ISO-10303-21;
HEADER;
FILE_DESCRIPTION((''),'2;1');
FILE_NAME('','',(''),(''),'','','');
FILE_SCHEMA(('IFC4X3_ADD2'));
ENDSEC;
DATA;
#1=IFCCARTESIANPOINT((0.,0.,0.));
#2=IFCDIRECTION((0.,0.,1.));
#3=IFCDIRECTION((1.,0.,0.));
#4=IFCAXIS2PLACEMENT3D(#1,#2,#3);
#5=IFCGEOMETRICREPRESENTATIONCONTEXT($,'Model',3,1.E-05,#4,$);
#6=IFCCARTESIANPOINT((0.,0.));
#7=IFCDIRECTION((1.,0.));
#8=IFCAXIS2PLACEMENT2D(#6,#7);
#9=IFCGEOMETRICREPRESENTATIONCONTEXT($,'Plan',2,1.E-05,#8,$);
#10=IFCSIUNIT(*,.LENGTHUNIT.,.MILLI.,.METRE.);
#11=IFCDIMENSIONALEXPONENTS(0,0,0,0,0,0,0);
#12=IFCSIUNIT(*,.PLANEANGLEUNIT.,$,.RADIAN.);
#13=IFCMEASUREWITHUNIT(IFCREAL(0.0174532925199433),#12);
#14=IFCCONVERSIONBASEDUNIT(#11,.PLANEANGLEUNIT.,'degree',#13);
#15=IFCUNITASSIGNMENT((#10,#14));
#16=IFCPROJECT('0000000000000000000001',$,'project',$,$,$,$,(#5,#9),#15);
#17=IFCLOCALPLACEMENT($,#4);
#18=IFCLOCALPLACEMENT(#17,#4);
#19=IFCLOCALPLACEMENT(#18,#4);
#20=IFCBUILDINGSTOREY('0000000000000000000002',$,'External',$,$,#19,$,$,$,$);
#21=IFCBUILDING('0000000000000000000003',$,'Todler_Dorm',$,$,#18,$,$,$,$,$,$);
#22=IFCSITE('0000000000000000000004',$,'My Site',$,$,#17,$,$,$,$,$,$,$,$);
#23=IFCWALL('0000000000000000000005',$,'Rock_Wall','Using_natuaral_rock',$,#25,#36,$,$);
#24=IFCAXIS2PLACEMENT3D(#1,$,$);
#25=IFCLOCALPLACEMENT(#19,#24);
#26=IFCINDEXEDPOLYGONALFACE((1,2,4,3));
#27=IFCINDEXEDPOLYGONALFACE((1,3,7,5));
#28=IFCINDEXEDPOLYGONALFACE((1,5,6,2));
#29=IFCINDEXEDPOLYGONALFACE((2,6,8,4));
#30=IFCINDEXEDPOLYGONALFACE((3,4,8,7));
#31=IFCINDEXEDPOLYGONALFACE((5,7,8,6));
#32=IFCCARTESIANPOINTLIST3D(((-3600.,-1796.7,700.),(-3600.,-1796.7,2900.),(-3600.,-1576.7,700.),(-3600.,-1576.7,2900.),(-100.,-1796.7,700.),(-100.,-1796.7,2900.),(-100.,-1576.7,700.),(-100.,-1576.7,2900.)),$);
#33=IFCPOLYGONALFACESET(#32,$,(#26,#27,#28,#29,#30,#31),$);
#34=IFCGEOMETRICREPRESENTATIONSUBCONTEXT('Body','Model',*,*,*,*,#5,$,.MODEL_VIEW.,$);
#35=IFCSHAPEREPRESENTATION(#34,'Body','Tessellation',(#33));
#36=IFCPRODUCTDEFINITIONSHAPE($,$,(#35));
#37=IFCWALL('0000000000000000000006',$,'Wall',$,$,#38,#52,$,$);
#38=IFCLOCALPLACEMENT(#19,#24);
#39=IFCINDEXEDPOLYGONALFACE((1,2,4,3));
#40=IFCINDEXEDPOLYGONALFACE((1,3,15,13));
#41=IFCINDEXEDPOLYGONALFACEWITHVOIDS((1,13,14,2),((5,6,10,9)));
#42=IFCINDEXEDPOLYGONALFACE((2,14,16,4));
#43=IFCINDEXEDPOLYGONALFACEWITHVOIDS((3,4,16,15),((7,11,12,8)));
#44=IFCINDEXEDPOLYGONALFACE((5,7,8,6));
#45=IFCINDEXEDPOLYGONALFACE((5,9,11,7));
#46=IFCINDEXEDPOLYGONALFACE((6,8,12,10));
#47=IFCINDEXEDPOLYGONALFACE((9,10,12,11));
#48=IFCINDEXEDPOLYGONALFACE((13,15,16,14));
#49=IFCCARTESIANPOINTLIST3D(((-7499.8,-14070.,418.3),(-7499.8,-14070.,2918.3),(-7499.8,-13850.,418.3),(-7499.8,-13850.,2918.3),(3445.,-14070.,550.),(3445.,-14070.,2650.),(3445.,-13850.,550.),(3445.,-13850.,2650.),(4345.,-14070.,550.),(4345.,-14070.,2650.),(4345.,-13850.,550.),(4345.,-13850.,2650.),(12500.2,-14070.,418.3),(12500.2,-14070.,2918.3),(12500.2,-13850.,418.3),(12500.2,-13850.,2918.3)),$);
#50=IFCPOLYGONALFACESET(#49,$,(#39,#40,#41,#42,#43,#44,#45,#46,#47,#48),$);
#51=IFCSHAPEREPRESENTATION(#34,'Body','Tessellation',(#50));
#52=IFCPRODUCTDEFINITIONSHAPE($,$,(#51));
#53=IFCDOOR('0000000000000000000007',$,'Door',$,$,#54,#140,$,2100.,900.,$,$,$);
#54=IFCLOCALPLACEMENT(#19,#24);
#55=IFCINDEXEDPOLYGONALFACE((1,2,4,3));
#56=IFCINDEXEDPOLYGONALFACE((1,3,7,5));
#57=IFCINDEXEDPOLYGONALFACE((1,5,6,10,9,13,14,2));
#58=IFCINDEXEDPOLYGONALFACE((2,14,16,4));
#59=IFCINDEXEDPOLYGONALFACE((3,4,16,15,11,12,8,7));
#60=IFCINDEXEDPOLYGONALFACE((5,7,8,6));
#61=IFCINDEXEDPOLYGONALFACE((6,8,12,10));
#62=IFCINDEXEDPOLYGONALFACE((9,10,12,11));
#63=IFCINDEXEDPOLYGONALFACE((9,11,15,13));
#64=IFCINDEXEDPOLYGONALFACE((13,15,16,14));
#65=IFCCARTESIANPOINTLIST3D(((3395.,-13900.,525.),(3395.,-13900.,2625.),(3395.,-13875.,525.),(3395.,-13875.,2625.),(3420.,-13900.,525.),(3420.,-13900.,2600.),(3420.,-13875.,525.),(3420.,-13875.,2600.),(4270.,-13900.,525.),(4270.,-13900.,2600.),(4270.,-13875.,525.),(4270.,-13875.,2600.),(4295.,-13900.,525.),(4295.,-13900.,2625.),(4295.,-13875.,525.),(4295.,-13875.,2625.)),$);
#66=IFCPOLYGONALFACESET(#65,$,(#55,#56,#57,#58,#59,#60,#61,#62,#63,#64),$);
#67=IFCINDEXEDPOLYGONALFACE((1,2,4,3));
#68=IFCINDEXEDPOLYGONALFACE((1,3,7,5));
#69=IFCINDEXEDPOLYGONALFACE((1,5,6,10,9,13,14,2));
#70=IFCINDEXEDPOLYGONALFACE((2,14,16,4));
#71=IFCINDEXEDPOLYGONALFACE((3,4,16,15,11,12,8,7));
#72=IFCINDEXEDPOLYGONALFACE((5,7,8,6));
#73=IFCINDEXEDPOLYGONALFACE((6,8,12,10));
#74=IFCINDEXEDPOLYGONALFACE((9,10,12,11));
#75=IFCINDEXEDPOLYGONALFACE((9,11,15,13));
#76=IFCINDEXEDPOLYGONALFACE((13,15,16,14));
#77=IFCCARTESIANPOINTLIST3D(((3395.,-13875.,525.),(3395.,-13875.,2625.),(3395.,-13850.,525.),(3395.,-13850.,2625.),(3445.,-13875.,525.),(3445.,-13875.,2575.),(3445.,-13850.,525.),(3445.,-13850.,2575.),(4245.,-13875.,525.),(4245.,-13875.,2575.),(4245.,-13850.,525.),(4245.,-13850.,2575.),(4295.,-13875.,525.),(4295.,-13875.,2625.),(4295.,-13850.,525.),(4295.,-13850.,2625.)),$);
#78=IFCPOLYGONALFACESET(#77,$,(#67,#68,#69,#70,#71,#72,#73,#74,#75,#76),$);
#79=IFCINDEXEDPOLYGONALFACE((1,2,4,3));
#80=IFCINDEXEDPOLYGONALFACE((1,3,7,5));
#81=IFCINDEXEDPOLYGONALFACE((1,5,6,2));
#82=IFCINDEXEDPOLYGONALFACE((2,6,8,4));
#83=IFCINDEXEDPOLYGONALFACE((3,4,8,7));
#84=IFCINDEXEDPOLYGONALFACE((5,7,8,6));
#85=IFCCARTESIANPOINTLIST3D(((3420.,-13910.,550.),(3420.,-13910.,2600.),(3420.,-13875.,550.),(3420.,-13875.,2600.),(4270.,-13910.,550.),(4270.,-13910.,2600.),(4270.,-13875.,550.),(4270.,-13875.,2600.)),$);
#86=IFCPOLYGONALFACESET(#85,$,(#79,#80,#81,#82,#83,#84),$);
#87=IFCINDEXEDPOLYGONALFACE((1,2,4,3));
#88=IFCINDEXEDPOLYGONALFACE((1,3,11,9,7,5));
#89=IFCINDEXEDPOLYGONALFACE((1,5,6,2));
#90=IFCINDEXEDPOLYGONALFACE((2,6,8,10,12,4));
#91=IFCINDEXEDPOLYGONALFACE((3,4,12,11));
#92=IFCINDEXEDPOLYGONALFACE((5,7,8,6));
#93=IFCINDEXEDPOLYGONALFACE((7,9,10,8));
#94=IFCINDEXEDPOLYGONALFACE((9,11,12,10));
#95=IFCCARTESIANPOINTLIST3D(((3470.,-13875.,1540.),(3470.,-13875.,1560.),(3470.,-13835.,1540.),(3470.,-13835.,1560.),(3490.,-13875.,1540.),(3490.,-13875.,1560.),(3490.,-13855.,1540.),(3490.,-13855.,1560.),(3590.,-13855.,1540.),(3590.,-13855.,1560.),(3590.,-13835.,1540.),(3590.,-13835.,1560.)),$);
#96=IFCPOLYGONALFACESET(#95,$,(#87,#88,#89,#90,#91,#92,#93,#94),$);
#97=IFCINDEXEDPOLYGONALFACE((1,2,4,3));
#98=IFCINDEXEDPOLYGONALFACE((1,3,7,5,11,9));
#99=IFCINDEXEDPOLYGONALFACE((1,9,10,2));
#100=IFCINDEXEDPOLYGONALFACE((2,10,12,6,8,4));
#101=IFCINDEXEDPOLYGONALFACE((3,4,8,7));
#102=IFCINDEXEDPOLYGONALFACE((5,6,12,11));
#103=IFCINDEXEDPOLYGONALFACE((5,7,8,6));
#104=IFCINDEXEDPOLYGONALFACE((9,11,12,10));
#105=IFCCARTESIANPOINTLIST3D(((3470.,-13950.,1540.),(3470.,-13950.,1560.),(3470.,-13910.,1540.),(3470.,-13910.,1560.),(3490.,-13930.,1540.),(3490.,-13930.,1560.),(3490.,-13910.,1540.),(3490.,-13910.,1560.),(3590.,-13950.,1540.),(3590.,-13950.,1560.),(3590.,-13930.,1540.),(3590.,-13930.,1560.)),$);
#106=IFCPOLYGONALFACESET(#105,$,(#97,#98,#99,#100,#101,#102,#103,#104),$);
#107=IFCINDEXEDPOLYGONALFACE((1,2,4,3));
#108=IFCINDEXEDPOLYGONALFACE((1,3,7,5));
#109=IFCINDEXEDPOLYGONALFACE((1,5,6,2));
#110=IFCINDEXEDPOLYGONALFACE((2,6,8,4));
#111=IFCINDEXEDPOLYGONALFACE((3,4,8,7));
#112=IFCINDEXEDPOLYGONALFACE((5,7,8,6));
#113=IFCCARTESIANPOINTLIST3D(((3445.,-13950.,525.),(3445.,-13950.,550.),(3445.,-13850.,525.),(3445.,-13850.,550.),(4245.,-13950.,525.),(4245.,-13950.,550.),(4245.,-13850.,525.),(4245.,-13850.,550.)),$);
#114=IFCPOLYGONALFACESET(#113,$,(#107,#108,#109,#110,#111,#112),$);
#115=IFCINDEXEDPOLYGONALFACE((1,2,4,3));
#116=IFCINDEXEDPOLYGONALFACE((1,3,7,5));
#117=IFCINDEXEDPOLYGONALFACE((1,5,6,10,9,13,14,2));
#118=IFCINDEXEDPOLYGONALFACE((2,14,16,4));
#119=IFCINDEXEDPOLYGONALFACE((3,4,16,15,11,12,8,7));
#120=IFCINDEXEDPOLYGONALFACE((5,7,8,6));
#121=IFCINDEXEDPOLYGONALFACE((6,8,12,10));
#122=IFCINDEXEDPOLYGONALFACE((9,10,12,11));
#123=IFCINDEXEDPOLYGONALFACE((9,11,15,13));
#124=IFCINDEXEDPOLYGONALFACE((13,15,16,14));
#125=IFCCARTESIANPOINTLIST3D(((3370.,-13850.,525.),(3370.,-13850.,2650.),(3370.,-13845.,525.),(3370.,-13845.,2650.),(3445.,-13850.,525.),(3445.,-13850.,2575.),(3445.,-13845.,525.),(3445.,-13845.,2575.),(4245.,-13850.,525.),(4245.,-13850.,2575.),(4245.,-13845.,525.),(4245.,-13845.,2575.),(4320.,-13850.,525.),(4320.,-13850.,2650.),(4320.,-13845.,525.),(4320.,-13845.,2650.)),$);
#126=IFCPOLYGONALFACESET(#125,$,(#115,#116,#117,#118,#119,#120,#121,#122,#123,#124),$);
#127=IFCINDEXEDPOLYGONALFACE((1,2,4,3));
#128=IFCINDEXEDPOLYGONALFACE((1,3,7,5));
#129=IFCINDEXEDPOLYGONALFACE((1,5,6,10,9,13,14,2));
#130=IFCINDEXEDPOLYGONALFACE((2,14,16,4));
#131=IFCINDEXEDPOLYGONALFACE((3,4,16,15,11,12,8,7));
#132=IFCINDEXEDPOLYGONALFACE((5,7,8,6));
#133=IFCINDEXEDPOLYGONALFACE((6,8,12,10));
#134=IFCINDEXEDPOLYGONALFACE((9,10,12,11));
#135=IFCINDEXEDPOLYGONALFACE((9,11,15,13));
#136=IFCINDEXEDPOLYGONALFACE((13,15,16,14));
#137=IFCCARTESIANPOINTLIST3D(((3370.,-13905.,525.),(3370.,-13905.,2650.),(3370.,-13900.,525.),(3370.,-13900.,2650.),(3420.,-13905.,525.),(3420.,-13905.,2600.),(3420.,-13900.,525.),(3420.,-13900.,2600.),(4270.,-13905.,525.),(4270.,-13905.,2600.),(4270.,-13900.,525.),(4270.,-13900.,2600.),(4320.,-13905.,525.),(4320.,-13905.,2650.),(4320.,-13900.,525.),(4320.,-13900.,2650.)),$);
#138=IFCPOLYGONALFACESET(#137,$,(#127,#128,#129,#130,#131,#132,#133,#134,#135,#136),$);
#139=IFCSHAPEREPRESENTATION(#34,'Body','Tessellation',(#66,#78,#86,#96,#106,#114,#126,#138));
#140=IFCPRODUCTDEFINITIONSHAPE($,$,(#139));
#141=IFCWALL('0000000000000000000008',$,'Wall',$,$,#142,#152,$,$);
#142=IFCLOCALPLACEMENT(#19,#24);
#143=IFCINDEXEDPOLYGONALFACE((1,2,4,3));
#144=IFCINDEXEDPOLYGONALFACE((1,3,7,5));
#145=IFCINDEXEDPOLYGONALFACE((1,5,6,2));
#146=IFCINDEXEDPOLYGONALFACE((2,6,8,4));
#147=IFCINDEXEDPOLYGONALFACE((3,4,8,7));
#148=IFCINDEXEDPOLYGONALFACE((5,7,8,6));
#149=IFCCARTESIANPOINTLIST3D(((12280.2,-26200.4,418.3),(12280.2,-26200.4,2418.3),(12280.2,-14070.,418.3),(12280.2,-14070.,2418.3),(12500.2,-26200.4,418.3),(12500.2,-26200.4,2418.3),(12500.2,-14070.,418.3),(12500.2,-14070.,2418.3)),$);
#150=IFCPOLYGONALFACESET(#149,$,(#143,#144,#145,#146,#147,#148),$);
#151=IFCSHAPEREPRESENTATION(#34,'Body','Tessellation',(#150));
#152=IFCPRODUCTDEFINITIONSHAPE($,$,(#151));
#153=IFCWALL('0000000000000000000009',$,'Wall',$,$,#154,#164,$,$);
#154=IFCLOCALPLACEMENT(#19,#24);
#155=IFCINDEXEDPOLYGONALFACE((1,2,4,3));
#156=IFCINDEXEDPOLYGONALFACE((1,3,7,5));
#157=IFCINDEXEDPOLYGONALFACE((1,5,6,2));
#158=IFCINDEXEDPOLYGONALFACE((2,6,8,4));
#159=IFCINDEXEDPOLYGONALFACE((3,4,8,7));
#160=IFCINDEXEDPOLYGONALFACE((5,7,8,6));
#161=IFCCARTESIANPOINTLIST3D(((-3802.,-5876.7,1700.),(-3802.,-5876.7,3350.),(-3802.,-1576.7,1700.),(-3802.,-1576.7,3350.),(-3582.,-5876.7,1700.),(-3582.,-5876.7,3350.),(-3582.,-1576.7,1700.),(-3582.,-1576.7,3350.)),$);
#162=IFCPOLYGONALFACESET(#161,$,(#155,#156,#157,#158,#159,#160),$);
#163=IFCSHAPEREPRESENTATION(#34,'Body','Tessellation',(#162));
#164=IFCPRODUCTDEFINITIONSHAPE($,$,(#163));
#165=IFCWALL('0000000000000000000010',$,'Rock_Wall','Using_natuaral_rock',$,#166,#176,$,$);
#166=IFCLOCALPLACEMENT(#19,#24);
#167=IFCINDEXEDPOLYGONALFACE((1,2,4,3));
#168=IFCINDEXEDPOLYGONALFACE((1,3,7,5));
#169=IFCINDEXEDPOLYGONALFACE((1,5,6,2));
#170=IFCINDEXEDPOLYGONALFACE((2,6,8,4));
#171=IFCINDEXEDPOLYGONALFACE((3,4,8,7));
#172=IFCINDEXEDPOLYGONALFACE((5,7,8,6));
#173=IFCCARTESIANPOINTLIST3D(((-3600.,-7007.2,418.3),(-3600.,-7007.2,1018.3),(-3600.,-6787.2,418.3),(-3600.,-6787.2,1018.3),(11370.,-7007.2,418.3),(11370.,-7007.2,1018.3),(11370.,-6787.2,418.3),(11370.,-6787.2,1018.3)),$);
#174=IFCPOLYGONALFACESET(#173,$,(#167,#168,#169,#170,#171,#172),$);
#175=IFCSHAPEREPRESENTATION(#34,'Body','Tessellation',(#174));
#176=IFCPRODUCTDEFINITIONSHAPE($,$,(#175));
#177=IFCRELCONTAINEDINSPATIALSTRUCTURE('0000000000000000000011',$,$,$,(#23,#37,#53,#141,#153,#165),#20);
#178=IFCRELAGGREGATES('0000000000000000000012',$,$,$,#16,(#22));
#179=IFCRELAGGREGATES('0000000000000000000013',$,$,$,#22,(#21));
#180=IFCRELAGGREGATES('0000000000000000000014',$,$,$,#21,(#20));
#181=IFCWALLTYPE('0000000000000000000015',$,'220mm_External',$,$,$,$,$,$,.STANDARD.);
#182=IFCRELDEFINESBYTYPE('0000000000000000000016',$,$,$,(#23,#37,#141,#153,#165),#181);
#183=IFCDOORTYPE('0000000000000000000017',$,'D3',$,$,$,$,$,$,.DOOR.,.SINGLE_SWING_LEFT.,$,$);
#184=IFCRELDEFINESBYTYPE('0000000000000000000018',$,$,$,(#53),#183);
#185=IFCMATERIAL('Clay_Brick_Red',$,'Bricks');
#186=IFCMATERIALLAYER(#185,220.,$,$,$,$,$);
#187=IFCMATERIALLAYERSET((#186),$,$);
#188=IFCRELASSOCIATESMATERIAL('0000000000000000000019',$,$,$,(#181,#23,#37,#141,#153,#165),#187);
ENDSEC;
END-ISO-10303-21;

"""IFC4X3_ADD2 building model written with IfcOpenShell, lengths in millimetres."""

from ifc_helpers import new_model, entity, si_unit, converted_unit, frame, origin_with_axes, origin_2d_with_axis, place, context, subcontext, project, spatial, line, indexed_curve, outline, extrude, shape, source, transform, mapped, material, layer, layer_set, layer_usage, type_object, type_shapes, element, fill, save


model = new_model("IFC4X3_ADD2")

# Units and contexts
model_context = context("Model", 3, precision=1e-05, world=origin_with_axes())
plan_context = context("Plan", 2, precision=1e-05, world=origin_2d_with_axis())
body_context_1 = subcontext(model_context, "Body", "Model", "MODEL_VIEW")
body_context_2 = subcontext(plan_context, "Body", "Plan", "PLAN_VIEW")
ifc_project = project(units=[si_unit("LENGTHUNIT", "METRE", prefix="MILLI"), converted_unit("PLANEANGLEUNIT", "degree", entity("IfcReal", 0.0174532925199433), si_unit("PLANEANGLEUNIT", "RADIAN"), dimensions=[0, 0, 0, 0, 0, 0, 0])], contexts=[model_context, plan_context])

# Site, building, storey
site_placement = place(None, origin_with_axes())
site = spatial("IfcSite", under=ifc_project, at=site_placement, Name="My Site")
building_placement = place(site_placement, origin_with_axes())
building = spatial("IfcBuilding", under=site, at=building_placement, Name="Todler_Dorm")
storey_placement = place(building_placement, origin_with_axes())
storey = spatial("IfcBuildingStorey", under=building, at=storey_placement, Name="External")

# Wall
ifc_material_1 = material(Name="Clay_Brick_Red", Category="Bricks")
ifc_layer_1 = layer(ifc_material_1, 220.0)
ifc_layer_set_1 = layer_set([ifc_layer_1])
ifc_layer_usage_1 = layer_usage(ifc_layer_set_1, "AXIS2", "POSITIVE", 0.0)
wall_type_1 = type_object("IfcWallType", Name="220mm_External", PredefinedType="STANDARD", material=ifc_layer_set_1)
wall_1_placement = place(storey_placement, frame((-3600.0, -1796.7, 700.0), z_axis=(0.0, 0.0, 1.0), x_axis=(1.0, 0.0, 0.0)))
element("IfcWall", 1, at=wall_1_placement, inside=storey, type_object=wall_type_1, material=ifc_layer_usage_1, Name="Rock_Wall", Description="Using_natuaral_rock", context=body_context_1, shape_type="SweptSolid", body=[
    extrude(outline(indexed_curve([(0.0, 0.0), (0.0, 220.0), (3500.0, 220.0), (3500.0, 0.0)], segments=[line(1, 2, 3, 4, 1)])), origin_with_axes(), (0.0, 0.0, 1.0), 2200.0),
])

# Wall, opening, door
ifc_layer_usage_2 = layer_usage(ifc_layer_set_1, "AXIS2", "POSITIVE", 0.0)
wall_2_placement = place(storey_placement, frame((12500.2, -13850.0, 418.3), z_axis=(0.0, 0.0, 1.0), x_axis=(-1.0, 0.0, 0.0)))
wall_2 = element("IfcWall", 2, at=wall_2_placement, inside=storey, type_object=wall_type_1, material=ifc_layer_usage_2, Name="Wall", context=body_context_1, shape_type="SweptSolid", body=[
    extrude(outline(indexed_curve([(0.0, 0.0), (0.0, 220.0), (20000.0, 220.0), (20000.0, 0.0)], segments=[line(1, 2, 3, 4, 1)])), origin_with_axes(), (0.0, 0.0, 1.0), 2500.0),
])
shared_shape_1 = source(origin_with_axes(), body_context_1, "Body", "SweptSolid", [
    extrude(outline(indexed_curve([(0.0, 0.0), (900.0, 0.0), (900.0, 2100.0), (0.0, 2100.0)], segments=[line(1, 2, 3, 4, 1)])), frame((0.0, -600.0, 0.0), z_axis=(0.0, -1.0, 0.0), x_axis=(1.0, 0.0, 0.0)), (0.0, 0.0, -1.0), 1200.0),
])
opening_placement = place(wall_2_placement, frame((8155.2, 0.0, 131.7), z_axis=(0.0, 0.0, 1.0), x_axis=(1.0, 0.0, 0.0)))
opening = element("IfcOpeningElement", 3, at=opening_placement, cuts=wall_2, PredefinedType="OPENING", context=body_context_1, shape_type="MappedRepresentation", body=[
    mapped(shared_shape_1, transform((0.0, 0.0, 0.0), x_axis=(1.0, 0.0, 0.0), y_axis=(0.0, 1.0, 0.0), z_axis=(0.0, 0.0, 1.0), scale=1.0)),
])
door_type = type_object("IfcDoorType", Name="D3", OperationType="SINGLE_SWING_LEFT", PredefinedType="DOOR")
shared_shape_2 = source(origin_with_axes(), body_context_1, "Body", "SweptSolid", [
    extrude(outline(indexed_curve([(0.0, 0.0), (0.0, 2100.0), (900.0, 2100.0), (900.0, 0.0), (875.0, 0.0), (875.0, 2075.0), (25.0, 2075.0), (25.0, 0.0)], segments=[line(1, 2, 3, 4, 5, 6, 7, 8, 1)])), frame((0.0, 25.0, 0.0), z_axis=(0.0, -1.0, 0.0), x_axis=(1.0, 0.0, 0.0)), (0.0, 0.0, -1.0), 25.0),
    extrude(outline(indexed_curve([(0.0, 0.0), (0.0, 2100.0), (900.0, 2100.0), (900.0, 0.0), (850.0, 0.0), (850.0, 2050.0), (50.0, 2050.0), (50.0, 0.0)], segments=[line(1, 2, 3, 4, 5, 6, 7, 8, 1)])), frame((0.0, 0.0, 0.0), z_axis=(0.0, -1.0, 0.0), x_axis=(1.0, 0.0, 0.0)), (0.0, 0.0, -1.0), 25.0),
    extrude(outline(indexed_curve([(0.0, 0.0), (850.0, 0.0), (850.0, 35.0), (0.0, 35.0)], segments=[line(1, 2, 3, 4, 1)])), frame((25.0, 25.0, 25.0), z_axis=(0.0, 0.0, 1.0), x_axis=(1.0, 0.0, 0.0)), (0.0, 0.0, 1.0), 2050.0),
    extrude(outline(indexed_curve([(0.0, 0.0), (0.0, -40.0), (-120.0, -40.0), (-120.0, -20.0), (-20.0, -20.0), (-20.0, 0.0)], segments=[line(1, 2, 3, 4, 5, 6, 1)])), frame((825.0, 25.0, 1015.0), z_axis=(0.0, 0.0, 1.0), x_axis=(1.0, 0.0, 0.0)), (0.0, 0.0, 1.0), 20.0),
    extrude(outline(indexed_curve([(0.0, 0.0), (0.0, 40.0), (-120.0, 40.0), (-120.0, 20.0), (-20.0, 20.0), (-20.0, 0.0)], segments=[line(1, 2, 3, 4, 5, 6, 1)])), frame((825.0, 60.0, 1015.0), z_axis=(0.0, 0.0, 1.0), x_axis=(1.0, 0.0, 0.0)), (0.0, 0.0, 1.0), 20.0),
    extrude(outline(indexed_curve([(0.0, 0.0), (800.0, 0.0), (800.0, 100.0), (0.0, 100.0)], segments=[line(1, 2, 3, 4, 1)])), frame((50.0, 0.0, 0.0), z_axis=(0.0, 0.0, 1.0), x_axis=(1.0, 0.0, 0.0)), (0.0, 0.0, 1.0), 25.0),
    extrude(outline(indexed_curve([(0.0, 0.0), (0.0, 2125.0), (950.0, 2125.0), (950.0, 0.0), (875.0, 0.0), (875.0, 2050.0), (75.0, 2050.0), (75.0, 0.0)], segments=[line(1, 2, 3, 4, 5, 6, 7, 8, 1)])), frame((-25.0, -5.0, 0.0), z_axis=(0.0, -1.0, 0.0), x_axis=(1.0, 0.0, 0.0)), (0.0, 0.0, -1.0), 5.0),
    extrude(outline(indexed_curve([(0.0, 0.0), (0.0, 2125.0), (950.0, 2125.0), (950.0, 0.0), (900.0, 0.0), (900.0, 2075.0), (50.0, 2075.0), (50.0, 0.0)], segments=[line(1, 2, 3, 4, 5, 6, 7, 8, 1)])), frame((-25.0, 50.0, 0.0), z_axis=(0.0, -1.0, 0.0), x_axis=(1.0, 0.0, 0.0)), (0.0, 0.0, -1.0), 5.0),
])
shared_shape_3 = source(origin_with_axes(), body_context_2, "Body", "Curve2D", [
    entity("IfcIndexedPolyCurve", entity("IfcCartesianPointList2D", [[0.0, 0.0], [0.0, 50.0], [25.0, 50.0], [25.0, 25.0], [50.0, 25.0], [50.0, 0.0]]), [entity("IfcLineIndex", [1, 2, 3, 4, 5, 6, 1])]),
    entity("IfcIndexedPolyCurve", entity("IfcCartesianPointList2D", [[900.0, 0.0], [900.0, 50.0], [875.0, 50.0], [875.0, 25.0], [850.0, 25.0], [850.0, 0.0]]), [entity("IfcLineIndex", [1, 2, 3, 4, 5, 6, 1])]),
    entity("IfcTrimmedCurve", entity("IfcEllipse", entity("IfcAxis2Placement2D", entity("IfcCartesianPoint", [60.0, 50.0]), entity("IfcDirection", [1.0, 0.0])), 815.0, 850.0), [entity("IfcCartesianPoint", [875.0, 50.0])], [entity("IfcCartesianPoint", [60.0, 900.0])], True, "CARTESIAN"),
    entity("IfcIndexedPolyCurve", entity("IfcCartesianPointList2D", [[25.0, 50.0], [60.0, 50.0], [60.0, 900.0], [25.0, 900.0]]), [entity("IfcLineIndex", [1, 2, 3, 4, 1])]),
])
type_shapes(door_type, [shared_shape_2, shared_shape_3])
door_placement = place(opening_placement, frame((50.0, 0.0, -25.0), z_axis=(0.0, 0.0, 1.0), x_axis=(1.0, 0.0, 0.0)))
door = element("IfcDoor", 4, at=door_placement, inside=storey, type_object=door_type, Name="Door", OverallHeight=2100.0, OverallWidth=900.0, shapes=[
    shape(body_context_1, "Body", "MappedRepresentation", [mapped(shared_shape_2, transform((0.0, 0.0, 0.0), x_axis=(1.0, 0.0, 0.0), y_axis=(0.0, 1.0, 0.0), z_axis=(0.0, 0.0, 1.0), scale=1.0))]),
    shape(body_context_2, "Body", "MappedRepresentation", [mapped(shared_shape_3, transform((0.0, 0.0, 0.0), x_axis=(1.0, 0.0, 0.0), y_axis=(0.0, 1.0, 0.0), z_axis=(0.0, 0.0, 1.0), scale=1.0))]),
])
fill(opening, door)

# Walls
ifc_layer_usage_3 = layer_usage(ifc_layer_set_1, "AXIS2", "POSITIVE", 0.0)
wall_3_placement = place(storey_placement, frame((12500.2, -26200.4, 418.3), z_axis=(0.0, 0.0, 1.0), x_axis=(0.0, 1.0, 0.0)))
element("IfcWall", 5, at=wall_3_placement, inside=storey, type_object=wall_type_1, material=ifc_layer_usage_3, Name="Wall", context=body_context_1, shape_type="SweptSolid", body=[
    extrude(outline(indexed_curve([(0.0, 0.0), (0.0, 220.0), (12130.4, 220.0), (12130.4, 0.0)], segments=[line(1, 2, 3, 4, 1)])), origin_with_axes(), (0.0, 0.0, 1.0), 2000.0),
])
ifc_layer_usage_4 = layer_usage(ifc_layer_set_1, "AXIS2", "POSITIVE", 0.0)
wall_4_placement = place(storey_placement, frame((-3802.0, -1576.7, 1700.0), z_axis=(0.0, 0.0, 1.0), x_axis=(0.000001, -1.0, 0.0)))
element("IfcWall", 6, at=wall_4_placement, inside=storey, type_object=wall_type_1, material=ifc_layer_usage_4, Name="Wall", context=body_context_1, shape_type="SweptSolid", body=[
    extrude(outline(indexed_curve([(0.0, 0.0), (0.0, 220.0), (4300.0, 220.0), (4300.0, 0.0)], segments=[line(1, 2, 3, 4, 1)])), origin_with_axes(), (0.0, 0.0, 1.0), 1650.0),
])
ifc_layer_usage_5 = layer_usage(ifc_layer_set_1, "AXIS2", "POSITIVE", 0.0)
wall_5_placement = place(storey_placement, frame((-3600.0, -7007.2, 418.3), z_axis=(0.0, 0.0, 1.0), x_axis=(1.0, 0.0, 0.0)))
element("IfcWall", 7, at=wall_5_placement, inside=storey, type_object=wall_type_1, material=ifc_layer_usage_5, Name="Rock_Wall", Description="Using_natuaral_rock", context=body_context_1, shape_type="SweptSolid", body=[
    extrude(outline(indexed_curve([(0.0, 0.0), (0.0, 220.0), (14970.0, 220.0), (14970.0, 0.0)], segments=[line(1, 2, 3, 4, 1)])), origin_with_axes(), (0.0, 0.0, 1.0), 600.0),
])

save(model, "model.ifc")
